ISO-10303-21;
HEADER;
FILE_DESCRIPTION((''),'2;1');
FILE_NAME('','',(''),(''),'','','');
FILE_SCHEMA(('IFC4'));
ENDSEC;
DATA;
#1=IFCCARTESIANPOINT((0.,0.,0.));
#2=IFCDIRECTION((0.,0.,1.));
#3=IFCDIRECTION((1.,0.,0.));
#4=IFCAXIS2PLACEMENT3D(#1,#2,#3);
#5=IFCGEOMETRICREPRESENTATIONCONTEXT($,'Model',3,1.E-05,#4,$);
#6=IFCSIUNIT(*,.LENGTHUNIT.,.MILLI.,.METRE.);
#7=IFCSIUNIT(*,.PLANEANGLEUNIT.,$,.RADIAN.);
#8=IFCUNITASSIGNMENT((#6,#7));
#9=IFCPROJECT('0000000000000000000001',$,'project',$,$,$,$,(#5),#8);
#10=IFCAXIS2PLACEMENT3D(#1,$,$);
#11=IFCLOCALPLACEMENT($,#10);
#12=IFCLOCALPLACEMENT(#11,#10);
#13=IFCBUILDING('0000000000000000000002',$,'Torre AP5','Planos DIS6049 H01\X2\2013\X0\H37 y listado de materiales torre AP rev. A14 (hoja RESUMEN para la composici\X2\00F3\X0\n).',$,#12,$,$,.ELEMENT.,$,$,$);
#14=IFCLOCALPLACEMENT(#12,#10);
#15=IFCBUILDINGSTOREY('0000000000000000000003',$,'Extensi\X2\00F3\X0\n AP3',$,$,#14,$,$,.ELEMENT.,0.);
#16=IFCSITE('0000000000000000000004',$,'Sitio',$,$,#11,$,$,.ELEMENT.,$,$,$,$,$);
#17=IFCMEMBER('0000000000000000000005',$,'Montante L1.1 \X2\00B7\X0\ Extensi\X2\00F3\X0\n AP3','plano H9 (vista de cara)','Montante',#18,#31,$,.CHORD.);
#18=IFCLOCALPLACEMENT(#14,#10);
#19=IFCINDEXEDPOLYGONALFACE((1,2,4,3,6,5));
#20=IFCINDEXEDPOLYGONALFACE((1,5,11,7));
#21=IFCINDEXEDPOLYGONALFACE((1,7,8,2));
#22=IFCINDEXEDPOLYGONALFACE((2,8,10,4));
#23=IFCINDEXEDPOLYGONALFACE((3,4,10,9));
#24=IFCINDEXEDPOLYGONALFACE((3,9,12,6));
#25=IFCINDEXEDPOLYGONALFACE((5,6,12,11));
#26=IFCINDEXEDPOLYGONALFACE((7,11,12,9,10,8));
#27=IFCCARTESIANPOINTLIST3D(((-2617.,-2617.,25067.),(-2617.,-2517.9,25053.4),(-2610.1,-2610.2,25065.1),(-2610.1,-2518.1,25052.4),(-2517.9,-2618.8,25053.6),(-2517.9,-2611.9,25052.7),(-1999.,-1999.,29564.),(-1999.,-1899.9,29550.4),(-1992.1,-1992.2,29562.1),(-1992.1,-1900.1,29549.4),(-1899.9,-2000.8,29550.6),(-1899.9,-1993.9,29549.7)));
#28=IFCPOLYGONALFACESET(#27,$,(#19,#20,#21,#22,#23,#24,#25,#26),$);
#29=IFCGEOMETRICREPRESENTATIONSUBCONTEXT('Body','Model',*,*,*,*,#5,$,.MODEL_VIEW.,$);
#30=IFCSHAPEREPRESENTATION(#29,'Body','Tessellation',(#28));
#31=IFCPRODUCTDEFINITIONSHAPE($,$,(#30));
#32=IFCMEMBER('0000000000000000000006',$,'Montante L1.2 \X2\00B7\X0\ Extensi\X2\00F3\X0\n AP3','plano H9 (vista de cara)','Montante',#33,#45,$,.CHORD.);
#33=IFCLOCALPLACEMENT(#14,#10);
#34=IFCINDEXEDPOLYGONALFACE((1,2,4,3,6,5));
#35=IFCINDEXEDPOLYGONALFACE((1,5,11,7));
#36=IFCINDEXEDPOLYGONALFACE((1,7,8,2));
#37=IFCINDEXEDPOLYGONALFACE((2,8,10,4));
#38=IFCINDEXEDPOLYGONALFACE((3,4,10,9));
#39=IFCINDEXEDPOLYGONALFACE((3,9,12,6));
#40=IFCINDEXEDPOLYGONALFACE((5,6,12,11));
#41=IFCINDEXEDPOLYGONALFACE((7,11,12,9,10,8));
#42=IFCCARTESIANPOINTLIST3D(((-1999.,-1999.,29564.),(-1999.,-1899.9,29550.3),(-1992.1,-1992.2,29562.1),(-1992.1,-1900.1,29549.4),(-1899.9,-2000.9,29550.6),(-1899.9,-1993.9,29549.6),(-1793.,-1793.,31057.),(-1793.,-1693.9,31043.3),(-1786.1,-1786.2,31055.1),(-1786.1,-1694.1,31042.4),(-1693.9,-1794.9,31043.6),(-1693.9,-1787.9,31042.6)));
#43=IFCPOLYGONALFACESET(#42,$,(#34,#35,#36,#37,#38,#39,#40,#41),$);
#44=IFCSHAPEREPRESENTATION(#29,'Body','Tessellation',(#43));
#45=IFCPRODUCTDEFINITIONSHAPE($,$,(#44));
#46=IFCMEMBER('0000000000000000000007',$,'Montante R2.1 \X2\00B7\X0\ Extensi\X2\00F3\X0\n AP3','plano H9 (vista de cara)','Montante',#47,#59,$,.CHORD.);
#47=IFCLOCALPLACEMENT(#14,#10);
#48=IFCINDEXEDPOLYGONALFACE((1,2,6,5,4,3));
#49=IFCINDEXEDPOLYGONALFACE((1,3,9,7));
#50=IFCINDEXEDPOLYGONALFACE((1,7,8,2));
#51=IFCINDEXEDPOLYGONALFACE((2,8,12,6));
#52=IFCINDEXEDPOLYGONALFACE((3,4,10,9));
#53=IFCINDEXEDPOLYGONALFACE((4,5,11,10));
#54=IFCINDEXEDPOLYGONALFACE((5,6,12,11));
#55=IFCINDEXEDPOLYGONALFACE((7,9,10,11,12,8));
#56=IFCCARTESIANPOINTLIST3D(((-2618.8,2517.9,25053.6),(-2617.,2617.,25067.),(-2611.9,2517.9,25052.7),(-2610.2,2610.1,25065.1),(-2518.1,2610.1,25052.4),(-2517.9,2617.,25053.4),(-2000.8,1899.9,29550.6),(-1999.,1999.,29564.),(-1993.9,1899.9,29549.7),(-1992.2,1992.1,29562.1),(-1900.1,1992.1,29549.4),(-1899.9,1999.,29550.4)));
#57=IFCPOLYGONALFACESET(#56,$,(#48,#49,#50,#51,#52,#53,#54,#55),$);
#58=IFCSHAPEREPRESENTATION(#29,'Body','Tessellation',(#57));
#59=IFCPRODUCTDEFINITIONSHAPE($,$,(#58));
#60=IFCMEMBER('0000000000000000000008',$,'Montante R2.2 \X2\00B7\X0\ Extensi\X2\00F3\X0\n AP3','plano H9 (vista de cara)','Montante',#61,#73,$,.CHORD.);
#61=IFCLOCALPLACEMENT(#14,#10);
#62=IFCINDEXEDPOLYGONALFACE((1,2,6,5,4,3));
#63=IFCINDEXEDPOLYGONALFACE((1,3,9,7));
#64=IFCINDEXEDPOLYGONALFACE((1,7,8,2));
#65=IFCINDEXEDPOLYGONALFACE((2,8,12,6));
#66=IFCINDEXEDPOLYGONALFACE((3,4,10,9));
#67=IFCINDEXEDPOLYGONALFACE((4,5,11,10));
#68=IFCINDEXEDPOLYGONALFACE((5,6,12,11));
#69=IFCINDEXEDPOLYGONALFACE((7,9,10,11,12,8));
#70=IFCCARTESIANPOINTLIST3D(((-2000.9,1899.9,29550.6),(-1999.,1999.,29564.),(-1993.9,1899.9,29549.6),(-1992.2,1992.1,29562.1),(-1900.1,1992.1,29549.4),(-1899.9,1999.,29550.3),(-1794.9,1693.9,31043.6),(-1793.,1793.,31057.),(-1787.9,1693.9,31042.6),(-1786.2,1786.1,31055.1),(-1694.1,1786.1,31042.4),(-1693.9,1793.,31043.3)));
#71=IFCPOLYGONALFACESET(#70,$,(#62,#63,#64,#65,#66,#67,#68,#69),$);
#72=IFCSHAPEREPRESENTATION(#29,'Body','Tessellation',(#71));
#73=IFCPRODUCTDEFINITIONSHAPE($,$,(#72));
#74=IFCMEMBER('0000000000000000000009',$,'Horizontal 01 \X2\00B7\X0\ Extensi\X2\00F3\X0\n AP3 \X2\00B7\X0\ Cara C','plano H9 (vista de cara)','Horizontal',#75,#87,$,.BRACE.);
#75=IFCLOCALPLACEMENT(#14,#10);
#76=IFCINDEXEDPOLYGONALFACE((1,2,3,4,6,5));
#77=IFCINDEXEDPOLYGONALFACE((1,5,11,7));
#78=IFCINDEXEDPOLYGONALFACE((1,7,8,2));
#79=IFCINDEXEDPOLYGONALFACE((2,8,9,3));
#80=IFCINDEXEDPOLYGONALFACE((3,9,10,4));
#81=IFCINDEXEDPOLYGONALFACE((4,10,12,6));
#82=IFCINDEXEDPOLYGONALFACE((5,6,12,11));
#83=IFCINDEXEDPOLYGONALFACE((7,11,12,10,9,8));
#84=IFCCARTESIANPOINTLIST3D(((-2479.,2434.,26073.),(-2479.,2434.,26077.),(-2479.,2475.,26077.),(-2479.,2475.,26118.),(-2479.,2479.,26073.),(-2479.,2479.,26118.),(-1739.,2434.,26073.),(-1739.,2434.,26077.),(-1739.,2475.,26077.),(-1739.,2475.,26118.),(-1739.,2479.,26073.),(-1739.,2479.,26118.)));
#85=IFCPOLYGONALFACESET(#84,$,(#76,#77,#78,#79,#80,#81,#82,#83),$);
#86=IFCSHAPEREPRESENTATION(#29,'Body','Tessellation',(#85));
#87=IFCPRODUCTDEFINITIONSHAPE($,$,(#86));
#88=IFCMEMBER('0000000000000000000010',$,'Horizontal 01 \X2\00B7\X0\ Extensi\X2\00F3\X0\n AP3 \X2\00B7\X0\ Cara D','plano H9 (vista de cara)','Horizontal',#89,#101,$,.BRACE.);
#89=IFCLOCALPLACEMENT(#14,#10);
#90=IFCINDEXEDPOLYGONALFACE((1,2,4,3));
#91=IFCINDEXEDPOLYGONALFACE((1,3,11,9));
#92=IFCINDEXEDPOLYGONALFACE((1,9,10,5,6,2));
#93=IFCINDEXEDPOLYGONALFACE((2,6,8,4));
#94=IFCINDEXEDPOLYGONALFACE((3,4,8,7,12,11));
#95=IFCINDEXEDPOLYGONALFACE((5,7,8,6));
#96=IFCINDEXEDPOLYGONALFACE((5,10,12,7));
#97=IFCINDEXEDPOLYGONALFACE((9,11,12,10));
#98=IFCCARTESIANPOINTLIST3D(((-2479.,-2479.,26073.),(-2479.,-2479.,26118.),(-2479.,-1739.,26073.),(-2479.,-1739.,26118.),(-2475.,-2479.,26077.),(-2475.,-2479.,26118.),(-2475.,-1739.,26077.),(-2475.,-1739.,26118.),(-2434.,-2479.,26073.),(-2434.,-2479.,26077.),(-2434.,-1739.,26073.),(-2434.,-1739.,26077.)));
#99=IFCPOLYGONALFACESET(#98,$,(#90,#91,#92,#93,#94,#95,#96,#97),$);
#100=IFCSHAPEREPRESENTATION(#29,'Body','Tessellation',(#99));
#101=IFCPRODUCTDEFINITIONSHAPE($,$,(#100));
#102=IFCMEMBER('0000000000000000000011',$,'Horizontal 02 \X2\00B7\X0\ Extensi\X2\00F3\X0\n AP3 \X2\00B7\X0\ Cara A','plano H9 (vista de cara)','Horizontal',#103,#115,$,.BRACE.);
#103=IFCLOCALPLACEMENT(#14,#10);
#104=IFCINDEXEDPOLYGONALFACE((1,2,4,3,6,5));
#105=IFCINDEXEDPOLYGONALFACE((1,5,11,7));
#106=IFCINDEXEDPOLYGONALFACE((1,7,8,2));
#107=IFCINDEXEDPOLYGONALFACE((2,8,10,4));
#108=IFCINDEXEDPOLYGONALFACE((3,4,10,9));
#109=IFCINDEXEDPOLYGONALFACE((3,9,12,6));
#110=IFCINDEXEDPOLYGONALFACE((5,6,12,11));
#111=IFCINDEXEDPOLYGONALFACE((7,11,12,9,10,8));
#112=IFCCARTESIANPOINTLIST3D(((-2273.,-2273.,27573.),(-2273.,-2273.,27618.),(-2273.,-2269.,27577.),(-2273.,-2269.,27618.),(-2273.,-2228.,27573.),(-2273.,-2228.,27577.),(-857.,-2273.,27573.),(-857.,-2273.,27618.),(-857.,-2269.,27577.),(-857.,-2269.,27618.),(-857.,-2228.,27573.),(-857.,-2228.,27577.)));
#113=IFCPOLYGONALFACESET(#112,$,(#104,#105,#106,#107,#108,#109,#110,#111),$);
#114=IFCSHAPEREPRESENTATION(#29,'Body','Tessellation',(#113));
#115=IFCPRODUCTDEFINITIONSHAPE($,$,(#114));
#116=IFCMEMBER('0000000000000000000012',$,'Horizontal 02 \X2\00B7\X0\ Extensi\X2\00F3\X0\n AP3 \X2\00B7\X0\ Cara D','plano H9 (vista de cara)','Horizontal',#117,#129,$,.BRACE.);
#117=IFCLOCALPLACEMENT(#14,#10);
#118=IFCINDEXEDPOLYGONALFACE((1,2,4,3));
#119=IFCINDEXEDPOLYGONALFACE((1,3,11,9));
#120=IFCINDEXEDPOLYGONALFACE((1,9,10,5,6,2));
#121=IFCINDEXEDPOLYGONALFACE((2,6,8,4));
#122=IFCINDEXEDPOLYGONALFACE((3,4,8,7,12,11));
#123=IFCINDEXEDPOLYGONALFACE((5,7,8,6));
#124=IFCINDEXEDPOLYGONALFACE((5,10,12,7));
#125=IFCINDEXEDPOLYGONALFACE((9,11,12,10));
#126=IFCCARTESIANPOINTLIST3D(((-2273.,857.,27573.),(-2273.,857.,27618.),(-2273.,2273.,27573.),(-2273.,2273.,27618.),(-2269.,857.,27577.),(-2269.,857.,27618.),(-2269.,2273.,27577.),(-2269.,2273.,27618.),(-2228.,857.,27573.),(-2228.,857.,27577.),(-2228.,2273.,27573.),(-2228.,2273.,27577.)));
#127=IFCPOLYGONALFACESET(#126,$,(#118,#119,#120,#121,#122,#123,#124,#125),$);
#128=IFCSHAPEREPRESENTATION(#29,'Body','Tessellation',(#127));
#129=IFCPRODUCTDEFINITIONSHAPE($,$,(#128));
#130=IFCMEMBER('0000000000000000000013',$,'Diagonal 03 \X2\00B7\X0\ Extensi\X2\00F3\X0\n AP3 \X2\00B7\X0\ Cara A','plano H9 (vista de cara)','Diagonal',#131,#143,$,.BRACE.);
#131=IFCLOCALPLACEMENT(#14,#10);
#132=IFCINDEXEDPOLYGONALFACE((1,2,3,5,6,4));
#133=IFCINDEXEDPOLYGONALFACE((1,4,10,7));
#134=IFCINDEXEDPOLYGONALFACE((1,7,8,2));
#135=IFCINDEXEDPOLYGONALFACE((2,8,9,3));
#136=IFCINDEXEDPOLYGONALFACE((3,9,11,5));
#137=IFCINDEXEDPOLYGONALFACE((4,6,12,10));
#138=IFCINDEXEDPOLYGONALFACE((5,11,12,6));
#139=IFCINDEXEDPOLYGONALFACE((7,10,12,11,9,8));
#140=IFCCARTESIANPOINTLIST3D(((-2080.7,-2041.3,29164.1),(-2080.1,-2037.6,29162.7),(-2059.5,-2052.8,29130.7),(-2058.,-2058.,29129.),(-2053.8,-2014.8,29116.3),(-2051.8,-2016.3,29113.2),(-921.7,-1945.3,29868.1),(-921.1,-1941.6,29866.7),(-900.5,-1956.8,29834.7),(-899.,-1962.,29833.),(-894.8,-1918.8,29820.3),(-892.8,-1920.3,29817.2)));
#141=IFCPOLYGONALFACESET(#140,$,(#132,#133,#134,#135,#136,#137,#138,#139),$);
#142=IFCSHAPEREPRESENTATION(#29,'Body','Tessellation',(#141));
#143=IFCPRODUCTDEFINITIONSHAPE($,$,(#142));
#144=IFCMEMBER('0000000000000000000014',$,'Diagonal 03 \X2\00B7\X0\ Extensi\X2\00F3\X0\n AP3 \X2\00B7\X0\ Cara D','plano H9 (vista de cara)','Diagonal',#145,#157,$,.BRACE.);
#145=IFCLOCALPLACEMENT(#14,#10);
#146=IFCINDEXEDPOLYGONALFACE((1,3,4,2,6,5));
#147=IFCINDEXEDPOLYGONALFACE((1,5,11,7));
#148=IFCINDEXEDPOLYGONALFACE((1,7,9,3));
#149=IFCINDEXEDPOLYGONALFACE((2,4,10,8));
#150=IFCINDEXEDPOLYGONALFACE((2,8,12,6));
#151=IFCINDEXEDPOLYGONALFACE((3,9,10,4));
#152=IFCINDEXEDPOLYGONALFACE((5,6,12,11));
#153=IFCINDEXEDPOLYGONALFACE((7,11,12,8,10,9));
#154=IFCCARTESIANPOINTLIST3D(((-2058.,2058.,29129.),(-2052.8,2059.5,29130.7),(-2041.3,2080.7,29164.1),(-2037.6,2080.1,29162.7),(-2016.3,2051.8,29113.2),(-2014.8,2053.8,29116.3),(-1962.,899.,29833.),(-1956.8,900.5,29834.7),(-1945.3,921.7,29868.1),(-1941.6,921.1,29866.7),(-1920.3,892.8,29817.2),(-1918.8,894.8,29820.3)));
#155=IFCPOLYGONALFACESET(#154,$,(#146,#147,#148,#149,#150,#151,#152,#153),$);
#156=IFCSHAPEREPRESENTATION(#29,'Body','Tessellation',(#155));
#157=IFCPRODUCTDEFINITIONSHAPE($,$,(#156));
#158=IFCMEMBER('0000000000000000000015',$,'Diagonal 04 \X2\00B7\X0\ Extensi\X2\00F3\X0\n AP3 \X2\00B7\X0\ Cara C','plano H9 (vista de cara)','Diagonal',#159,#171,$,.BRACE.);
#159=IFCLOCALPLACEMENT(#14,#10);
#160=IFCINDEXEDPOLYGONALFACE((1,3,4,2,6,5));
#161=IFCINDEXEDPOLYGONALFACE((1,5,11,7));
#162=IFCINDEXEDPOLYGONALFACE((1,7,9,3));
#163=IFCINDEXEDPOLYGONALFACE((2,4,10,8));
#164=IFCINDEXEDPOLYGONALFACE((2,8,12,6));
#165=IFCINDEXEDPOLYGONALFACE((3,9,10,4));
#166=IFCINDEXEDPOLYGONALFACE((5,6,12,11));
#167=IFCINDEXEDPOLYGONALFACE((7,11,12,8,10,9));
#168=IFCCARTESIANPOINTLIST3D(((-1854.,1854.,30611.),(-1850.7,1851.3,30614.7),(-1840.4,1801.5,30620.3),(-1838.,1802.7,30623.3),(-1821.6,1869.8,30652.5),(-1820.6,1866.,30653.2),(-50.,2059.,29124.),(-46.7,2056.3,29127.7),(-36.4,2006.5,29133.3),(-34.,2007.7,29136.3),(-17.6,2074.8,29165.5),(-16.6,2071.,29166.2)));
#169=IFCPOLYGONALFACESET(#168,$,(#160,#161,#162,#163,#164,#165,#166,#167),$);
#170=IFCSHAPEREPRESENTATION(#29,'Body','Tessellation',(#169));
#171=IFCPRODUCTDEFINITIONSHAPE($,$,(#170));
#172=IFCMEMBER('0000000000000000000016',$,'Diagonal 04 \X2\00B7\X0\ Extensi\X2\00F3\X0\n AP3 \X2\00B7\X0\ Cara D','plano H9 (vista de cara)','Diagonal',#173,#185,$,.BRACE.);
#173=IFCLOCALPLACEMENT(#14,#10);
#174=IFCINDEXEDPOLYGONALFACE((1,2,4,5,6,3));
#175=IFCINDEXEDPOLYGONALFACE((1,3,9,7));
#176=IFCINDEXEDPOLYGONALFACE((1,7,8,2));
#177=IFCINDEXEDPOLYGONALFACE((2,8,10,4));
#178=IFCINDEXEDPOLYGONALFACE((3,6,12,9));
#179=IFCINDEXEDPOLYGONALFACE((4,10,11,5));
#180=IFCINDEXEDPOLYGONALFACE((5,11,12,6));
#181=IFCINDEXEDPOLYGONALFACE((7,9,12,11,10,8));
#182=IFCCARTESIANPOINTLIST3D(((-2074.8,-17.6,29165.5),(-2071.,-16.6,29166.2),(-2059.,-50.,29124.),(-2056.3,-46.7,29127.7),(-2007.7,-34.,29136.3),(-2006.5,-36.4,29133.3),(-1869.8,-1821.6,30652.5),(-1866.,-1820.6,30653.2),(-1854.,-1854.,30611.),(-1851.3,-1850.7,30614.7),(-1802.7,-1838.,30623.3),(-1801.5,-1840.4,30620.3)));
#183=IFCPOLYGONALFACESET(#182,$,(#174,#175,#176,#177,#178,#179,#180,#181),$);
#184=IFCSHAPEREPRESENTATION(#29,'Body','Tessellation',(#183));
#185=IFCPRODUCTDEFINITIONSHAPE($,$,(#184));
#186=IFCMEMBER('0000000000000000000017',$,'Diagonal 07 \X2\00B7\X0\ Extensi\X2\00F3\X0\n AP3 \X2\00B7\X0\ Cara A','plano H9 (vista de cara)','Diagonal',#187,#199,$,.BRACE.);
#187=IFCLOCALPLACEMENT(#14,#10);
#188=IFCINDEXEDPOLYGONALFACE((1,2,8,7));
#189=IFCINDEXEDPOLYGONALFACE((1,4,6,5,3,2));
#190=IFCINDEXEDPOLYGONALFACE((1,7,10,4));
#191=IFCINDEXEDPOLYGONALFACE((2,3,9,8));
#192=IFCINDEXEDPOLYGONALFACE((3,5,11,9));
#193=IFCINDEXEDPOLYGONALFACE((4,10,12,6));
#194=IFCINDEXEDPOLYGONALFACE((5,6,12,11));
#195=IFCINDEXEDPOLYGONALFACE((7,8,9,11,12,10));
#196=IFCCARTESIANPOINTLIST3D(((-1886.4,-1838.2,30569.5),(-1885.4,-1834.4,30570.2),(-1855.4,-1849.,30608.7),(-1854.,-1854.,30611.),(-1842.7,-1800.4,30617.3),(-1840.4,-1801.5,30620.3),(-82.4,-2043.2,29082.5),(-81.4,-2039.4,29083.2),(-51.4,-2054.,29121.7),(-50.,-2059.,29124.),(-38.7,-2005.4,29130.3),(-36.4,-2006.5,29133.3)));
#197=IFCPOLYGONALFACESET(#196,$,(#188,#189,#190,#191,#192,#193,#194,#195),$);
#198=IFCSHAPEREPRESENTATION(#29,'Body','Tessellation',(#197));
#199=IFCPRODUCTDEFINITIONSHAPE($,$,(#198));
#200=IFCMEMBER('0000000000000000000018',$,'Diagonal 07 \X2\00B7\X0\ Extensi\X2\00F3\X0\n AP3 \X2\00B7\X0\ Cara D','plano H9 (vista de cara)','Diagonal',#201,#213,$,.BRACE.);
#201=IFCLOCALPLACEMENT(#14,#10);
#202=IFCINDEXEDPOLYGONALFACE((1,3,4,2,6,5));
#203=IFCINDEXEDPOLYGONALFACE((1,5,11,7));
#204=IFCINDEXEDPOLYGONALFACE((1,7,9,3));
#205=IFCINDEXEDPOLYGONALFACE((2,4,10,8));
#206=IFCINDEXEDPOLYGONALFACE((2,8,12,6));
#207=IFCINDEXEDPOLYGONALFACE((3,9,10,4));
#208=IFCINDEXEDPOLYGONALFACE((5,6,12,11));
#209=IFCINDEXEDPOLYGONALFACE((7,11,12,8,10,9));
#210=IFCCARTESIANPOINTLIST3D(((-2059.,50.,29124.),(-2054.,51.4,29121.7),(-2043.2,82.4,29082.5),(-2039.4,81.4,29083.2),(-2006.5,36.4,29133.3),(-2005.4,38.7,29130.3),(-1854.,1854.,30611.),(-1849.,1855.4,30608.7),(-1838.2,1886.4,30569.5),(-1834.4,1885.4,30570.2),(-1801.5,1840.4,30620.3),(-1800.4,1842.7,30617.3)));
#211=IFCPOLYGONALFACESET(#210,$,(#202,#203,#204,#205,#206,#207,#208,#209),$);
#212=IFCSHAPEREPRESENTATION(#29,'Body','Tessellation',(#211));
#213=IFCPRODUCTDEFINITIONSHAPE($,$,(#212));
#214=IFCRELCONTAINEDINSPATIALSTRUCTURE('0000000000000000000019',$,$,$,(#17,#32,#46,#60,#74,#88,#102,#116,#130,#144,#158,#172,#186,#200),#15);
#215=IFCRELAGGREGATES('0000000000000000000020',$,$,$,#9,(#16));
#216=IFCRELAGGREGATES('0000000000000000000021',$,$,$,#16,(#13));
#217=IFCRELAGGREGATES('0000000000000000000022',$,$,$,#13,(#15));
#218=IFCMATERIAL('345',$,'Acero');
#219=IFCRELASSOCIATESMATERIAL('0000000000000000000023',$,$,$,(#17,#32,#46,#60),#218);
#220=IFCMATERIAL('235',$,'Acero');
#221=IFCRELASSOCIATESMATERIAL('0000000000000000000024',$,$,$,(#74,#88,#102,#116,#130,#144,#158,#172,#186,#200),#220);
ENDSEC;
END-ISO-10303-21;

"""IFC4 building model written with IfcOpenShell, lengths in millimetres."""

from ifc_helpers import new_model, si_unit, frame, frame_2d, origin, origin_with_axes, place, context, subcontext, project, spatial, l_section, extrude, material, element, save


model = new_model("IFC4")

# Units and contexts
model_context = context("Model", 3, precision=1e-05, world=origin_with_axes())
body_context = subcontext(model_context, "Body", "Model", "MODEL_VIEW")
ifc_project = project(units=[si_unit("LENGTHUNIT", "METRE", prefix="MILLI"), si_unit("PLANEANGLEUNIT", "RADIAN")], contexts=[model_context])

# Site, building, storey
site_placement = place(None, origin())
site = spatial("IfcSite", under=ifc_project, at=site_placement, Name="Sitio", CompositionType="ELEMENT")
building_placement = place(site_placement, origin())
building = spatial("IfcBuilding", under=site, at=building_placement, Name="Torre AP5", Description="Planos DIS6049 H01–H37 y listado de materiales torre AP rev. A14 (hoja RESUMEN para la composición).", CompositionType="ELEMENT")
storey_placement = place(building_placement, origin())
storey = spatial("IfcBuildingStorey", under=building, at=storey_placement, Name="Extensión AP3", CompositionType="ELEMENT", Elevation=0.0)

# Members
ifc_material_1 = material(Name="345", Category="Acero")
member_1_placement = place(storey_placement, frame((-2617.0, -2617.0, 25067.0), z_axis=(0.134901, 0.134901, 0.981633), x_axis=(0.990859, -0.018366, -0.133645)))
element("IfcMember", 1, at=member_1_placement, inside=storey, material=ifc_material_1, Name="Montante L1.1 · Extensión AP3", Description="plano H9 (vista de cara)", ObjectType="Montante", PredefinedType="CHORD", context=body_context, shape_type="SweptSolid", body=[
    extrude(l_section(Depth=100.0, Width=100.0, Thickness=7.0, at=frame_2d((50.0, 50.0))), None, (0.0, 0.0, 1.0), 4581.1),
])
member_2_placement = place(storey_placement, frame((-1999.0, -1999.0, 29564.0), z_axis=(0.135423, 0.135423, 0.981489), x_axis=(0.990788, -0.01851, -0.134152)))
element("IfcMember", 2, at=member_2_placement, inside=storey, material=ifc_material_1, Name="Montante L1.2 · Extensión AP3", Description="plano H9 (vista de cara)", ObjectType="Montante", PredefinedType="CHORD", context=body_context, shape_type="SweptSolid", body=[
    extrude(l_section(Depth=100.0, Width=100.0, Thickness=7.0, at=frame_2d((50.0, 50.0))), None, (0.0, 0.0, 1.0), 1521.2),
])
member_3_placement = place(storey_placement, frame((-2617.0, 2617.0, 25067.0), z_axis=(0.134901, -0.134901, 0.981633), x_axis=(-0.018366, -0.990859, -0.133645)))
element("IfcMember", 3, at=member_3_placement, inside=storey, material=ifc_material_1, Name="Montante R2.1 · Extensión AP3", Description="plano H9 (vista de cara)", ObjectType="Montante", PredefinedType="CHORD", context=body_context, shape_type="SweptSolid", body=[
    extrude(l_section(Depth=100.0, Width=100.0, Thickness=7.0, at=frame_2d((50.0, 50.0))), None, (0.0, 0.0, 1.0), 4581.1),
])
member_4_placement = place(storey_placement, frame((-1999.0, 1999.0, 29564.0), z_axis=(0.135423, -0.135423, 0.981489), x_axis=(-0.01851, -0.990788, -0.134152)))
element("IfcMember", 4, at=member_4_placement, inside=storey, material=ifc_material_1, Name="Montante R2.2 · Extensión AP3", Description="plano H9 (vista de cara)", ObjectType="Montante", PredefinedType="CHORD", context=body_context, shape_type="SweptSolid", body=[
    extrude(l_section(Depth=100.0, Width=100.0, Thickness=7.0, at=frame_2d((50.0, 50.0))), None, (0.0, 0.0, 1.0), 1521.2),
])
ifc_material_2 = material(Name="235", Category="Acero")
for number, where, z_axis, x_axis, name in (
    (5, (-1739.0, 2479.0, 26073.0), (-1.0, 0.0, 0.0), (0.0, -1.0, 0.0), "Horizontal 01 · Extensión AP3 · Cara C"),
    (6, (-2479.0, -1739.0, 26073.0), (0.0, -1.0, 0.0), (1.0, 0.0, 0.0), "Horizontal 01 · Extensión AP3 · Cara D"),
):
    element("IfcMember", number, at=place(storey_placement, frame(where, z_axis=z_axis, x_axis=x_axis)), inside=storey, material=ifc_material_2, Name=name, Description="plano H9 (vista de cara)", ObjectType="Horizontal", PredefinedType="BRACE", context=body_context, shape_type="SweptSolid", body=[
        extrude(l_section(Depth=45.0, Width=45.0, Thickness=4.0, at=frame_2d((22.5, 22.5))), None, (0.0, 0.0, 1.0), 740.0),
    ])
for number, where, z_axis, x_axis, name in (
    (7, (-2273.0, -2273.0, 27573.0), (1.0, 0.0, 0.0), (0.0, 1.0, 0.0), "Horizontal 02 · Extensión AP3 · Cara A"),
    (8, (-2273.0, 2273.0, 27573.0), (0.0, -1.0, 0.0), (1.0, 0.0, 0.0), "Horizontal 02 · Extensión AP3 · Cara D"),
):
    element("IfcMember", number, at=place(storey_placement, frame(where, z_axis=z_axis, x_axis=x_axis)), inside=storey, material=ifc_material_2, Name=name, Description="plano H9 (vista de cara)", ObjectType="Horizontal", PredefinedType="BRACE", context=body_context, shape_type="SweptSolid", body=[
        extrude(l_section(Depth=45.0, Width=45.0, Thickness=4.0, at=frame_2d((22.5, 22.5))), None, (0.0, 0.0, 1.0), 1416.0),
    ])
for number, where, z_axis, x_axis, name in (
    (9, (-2058.0, -2058.0, 29129.0), (0.852549, 0.070617, 0.517855), (0.137057, 0.925948, -0.351904), "Diagonal 03 · Extensión AP3 · Cara A"),
    (10, (-2058.0, 2058.0, 29129.0), (0.070617, -0.852549, 0.517855), (0.925948, -0.137057, -0.351904), "Diagonal 03 · Extensión AP3 · Cara D"),
):
    element("IfcMember", number, at=place(storey_placement, frame(where, z_axis=z_axis, x_axis=x_axis)), inside=storey, material=ifc_material_2, Name=name, Description="plano H9 (vista de cara)", ObjectType="Diagonal", PredefinedType="BRACE", context=body_context, shape_type="SweptSolid", body=[
        extrude(l_section(Depth=45.0, Width=45.0, Thickness=4.0, at=frame_2d((22.5, 22.5))), None, (0.0, 0.0, 1.0), 1359.5),
    ])
for number, where, z_axis, x_axis, name in (
    (11, (-50.0, 2059.0, 29124.0), (-0.768697, -0.087352, 0.633621), (0.247751, -0.953961, 0.169052), "Diagonal 04 · Extensión AP3 · Cara C"),
    (12, (-2059.0, -50.0, 29124.0), (0.087352, -0.768697, 0.633621), (0.953961, 0.247751, 0.169052), "Diagonal 04 · Extensión AP3 · Cara D"),
):
    element("IfcMember", number, at=place(storey_placement, frame(where, z_axis=z_axis, x_axis=x_axis)), inside=storey, material=ifc_material_2, Name=name, Description="plano H9 (vista de cara)", ObjectType="Diagonal", PredefinedType="BRACE", context=body_context, shape_type="SweptSolid", body=[
        extrude(l_section(Depth=55.0, Width=55.0, Thickness=4.0, at=frame_2d((27.5, 27.5))), None, (0.0, 0.0, 1.0), 2346.8),
    ])
for number, where, z_axis, x_axis, name in (
    (13, (-50.0, -2059.0, 29124.0), (-0.768697, 0.087352, 0.633621), (0.247751, 0.953961, 0.169052), "Diagonal 07 · Extensión AP3 · Cara A"),
    (14, (-2059.0, 50.0, 29124.0), (0.087352, 0.768697, 0.633621), (0.953961, -0.247751, 0.169052), "Diagonal 07 · Extensión AP3 · Cara D"),
):
    element("IfcMember", number, at=place(storey_placement, frame(where, z_axis=z_axis, x_axis=x_axis)), inside=storey, material=ifc_material_2, Name=name, Description="plano H9 (vista de cara)", ObjectType="Diagonal", PredefinedType="BRACE", context=body_context, shape_type="SweptSolid", body=[
        extrude(l_section(Depth=55.0, Width=55.0, Thickness=4.0, at=frame_2d((27.5, 27.5))), None, (0.0, 0.0, 1.0), 2346.8),
    ])

save(model, "model.ifc")
